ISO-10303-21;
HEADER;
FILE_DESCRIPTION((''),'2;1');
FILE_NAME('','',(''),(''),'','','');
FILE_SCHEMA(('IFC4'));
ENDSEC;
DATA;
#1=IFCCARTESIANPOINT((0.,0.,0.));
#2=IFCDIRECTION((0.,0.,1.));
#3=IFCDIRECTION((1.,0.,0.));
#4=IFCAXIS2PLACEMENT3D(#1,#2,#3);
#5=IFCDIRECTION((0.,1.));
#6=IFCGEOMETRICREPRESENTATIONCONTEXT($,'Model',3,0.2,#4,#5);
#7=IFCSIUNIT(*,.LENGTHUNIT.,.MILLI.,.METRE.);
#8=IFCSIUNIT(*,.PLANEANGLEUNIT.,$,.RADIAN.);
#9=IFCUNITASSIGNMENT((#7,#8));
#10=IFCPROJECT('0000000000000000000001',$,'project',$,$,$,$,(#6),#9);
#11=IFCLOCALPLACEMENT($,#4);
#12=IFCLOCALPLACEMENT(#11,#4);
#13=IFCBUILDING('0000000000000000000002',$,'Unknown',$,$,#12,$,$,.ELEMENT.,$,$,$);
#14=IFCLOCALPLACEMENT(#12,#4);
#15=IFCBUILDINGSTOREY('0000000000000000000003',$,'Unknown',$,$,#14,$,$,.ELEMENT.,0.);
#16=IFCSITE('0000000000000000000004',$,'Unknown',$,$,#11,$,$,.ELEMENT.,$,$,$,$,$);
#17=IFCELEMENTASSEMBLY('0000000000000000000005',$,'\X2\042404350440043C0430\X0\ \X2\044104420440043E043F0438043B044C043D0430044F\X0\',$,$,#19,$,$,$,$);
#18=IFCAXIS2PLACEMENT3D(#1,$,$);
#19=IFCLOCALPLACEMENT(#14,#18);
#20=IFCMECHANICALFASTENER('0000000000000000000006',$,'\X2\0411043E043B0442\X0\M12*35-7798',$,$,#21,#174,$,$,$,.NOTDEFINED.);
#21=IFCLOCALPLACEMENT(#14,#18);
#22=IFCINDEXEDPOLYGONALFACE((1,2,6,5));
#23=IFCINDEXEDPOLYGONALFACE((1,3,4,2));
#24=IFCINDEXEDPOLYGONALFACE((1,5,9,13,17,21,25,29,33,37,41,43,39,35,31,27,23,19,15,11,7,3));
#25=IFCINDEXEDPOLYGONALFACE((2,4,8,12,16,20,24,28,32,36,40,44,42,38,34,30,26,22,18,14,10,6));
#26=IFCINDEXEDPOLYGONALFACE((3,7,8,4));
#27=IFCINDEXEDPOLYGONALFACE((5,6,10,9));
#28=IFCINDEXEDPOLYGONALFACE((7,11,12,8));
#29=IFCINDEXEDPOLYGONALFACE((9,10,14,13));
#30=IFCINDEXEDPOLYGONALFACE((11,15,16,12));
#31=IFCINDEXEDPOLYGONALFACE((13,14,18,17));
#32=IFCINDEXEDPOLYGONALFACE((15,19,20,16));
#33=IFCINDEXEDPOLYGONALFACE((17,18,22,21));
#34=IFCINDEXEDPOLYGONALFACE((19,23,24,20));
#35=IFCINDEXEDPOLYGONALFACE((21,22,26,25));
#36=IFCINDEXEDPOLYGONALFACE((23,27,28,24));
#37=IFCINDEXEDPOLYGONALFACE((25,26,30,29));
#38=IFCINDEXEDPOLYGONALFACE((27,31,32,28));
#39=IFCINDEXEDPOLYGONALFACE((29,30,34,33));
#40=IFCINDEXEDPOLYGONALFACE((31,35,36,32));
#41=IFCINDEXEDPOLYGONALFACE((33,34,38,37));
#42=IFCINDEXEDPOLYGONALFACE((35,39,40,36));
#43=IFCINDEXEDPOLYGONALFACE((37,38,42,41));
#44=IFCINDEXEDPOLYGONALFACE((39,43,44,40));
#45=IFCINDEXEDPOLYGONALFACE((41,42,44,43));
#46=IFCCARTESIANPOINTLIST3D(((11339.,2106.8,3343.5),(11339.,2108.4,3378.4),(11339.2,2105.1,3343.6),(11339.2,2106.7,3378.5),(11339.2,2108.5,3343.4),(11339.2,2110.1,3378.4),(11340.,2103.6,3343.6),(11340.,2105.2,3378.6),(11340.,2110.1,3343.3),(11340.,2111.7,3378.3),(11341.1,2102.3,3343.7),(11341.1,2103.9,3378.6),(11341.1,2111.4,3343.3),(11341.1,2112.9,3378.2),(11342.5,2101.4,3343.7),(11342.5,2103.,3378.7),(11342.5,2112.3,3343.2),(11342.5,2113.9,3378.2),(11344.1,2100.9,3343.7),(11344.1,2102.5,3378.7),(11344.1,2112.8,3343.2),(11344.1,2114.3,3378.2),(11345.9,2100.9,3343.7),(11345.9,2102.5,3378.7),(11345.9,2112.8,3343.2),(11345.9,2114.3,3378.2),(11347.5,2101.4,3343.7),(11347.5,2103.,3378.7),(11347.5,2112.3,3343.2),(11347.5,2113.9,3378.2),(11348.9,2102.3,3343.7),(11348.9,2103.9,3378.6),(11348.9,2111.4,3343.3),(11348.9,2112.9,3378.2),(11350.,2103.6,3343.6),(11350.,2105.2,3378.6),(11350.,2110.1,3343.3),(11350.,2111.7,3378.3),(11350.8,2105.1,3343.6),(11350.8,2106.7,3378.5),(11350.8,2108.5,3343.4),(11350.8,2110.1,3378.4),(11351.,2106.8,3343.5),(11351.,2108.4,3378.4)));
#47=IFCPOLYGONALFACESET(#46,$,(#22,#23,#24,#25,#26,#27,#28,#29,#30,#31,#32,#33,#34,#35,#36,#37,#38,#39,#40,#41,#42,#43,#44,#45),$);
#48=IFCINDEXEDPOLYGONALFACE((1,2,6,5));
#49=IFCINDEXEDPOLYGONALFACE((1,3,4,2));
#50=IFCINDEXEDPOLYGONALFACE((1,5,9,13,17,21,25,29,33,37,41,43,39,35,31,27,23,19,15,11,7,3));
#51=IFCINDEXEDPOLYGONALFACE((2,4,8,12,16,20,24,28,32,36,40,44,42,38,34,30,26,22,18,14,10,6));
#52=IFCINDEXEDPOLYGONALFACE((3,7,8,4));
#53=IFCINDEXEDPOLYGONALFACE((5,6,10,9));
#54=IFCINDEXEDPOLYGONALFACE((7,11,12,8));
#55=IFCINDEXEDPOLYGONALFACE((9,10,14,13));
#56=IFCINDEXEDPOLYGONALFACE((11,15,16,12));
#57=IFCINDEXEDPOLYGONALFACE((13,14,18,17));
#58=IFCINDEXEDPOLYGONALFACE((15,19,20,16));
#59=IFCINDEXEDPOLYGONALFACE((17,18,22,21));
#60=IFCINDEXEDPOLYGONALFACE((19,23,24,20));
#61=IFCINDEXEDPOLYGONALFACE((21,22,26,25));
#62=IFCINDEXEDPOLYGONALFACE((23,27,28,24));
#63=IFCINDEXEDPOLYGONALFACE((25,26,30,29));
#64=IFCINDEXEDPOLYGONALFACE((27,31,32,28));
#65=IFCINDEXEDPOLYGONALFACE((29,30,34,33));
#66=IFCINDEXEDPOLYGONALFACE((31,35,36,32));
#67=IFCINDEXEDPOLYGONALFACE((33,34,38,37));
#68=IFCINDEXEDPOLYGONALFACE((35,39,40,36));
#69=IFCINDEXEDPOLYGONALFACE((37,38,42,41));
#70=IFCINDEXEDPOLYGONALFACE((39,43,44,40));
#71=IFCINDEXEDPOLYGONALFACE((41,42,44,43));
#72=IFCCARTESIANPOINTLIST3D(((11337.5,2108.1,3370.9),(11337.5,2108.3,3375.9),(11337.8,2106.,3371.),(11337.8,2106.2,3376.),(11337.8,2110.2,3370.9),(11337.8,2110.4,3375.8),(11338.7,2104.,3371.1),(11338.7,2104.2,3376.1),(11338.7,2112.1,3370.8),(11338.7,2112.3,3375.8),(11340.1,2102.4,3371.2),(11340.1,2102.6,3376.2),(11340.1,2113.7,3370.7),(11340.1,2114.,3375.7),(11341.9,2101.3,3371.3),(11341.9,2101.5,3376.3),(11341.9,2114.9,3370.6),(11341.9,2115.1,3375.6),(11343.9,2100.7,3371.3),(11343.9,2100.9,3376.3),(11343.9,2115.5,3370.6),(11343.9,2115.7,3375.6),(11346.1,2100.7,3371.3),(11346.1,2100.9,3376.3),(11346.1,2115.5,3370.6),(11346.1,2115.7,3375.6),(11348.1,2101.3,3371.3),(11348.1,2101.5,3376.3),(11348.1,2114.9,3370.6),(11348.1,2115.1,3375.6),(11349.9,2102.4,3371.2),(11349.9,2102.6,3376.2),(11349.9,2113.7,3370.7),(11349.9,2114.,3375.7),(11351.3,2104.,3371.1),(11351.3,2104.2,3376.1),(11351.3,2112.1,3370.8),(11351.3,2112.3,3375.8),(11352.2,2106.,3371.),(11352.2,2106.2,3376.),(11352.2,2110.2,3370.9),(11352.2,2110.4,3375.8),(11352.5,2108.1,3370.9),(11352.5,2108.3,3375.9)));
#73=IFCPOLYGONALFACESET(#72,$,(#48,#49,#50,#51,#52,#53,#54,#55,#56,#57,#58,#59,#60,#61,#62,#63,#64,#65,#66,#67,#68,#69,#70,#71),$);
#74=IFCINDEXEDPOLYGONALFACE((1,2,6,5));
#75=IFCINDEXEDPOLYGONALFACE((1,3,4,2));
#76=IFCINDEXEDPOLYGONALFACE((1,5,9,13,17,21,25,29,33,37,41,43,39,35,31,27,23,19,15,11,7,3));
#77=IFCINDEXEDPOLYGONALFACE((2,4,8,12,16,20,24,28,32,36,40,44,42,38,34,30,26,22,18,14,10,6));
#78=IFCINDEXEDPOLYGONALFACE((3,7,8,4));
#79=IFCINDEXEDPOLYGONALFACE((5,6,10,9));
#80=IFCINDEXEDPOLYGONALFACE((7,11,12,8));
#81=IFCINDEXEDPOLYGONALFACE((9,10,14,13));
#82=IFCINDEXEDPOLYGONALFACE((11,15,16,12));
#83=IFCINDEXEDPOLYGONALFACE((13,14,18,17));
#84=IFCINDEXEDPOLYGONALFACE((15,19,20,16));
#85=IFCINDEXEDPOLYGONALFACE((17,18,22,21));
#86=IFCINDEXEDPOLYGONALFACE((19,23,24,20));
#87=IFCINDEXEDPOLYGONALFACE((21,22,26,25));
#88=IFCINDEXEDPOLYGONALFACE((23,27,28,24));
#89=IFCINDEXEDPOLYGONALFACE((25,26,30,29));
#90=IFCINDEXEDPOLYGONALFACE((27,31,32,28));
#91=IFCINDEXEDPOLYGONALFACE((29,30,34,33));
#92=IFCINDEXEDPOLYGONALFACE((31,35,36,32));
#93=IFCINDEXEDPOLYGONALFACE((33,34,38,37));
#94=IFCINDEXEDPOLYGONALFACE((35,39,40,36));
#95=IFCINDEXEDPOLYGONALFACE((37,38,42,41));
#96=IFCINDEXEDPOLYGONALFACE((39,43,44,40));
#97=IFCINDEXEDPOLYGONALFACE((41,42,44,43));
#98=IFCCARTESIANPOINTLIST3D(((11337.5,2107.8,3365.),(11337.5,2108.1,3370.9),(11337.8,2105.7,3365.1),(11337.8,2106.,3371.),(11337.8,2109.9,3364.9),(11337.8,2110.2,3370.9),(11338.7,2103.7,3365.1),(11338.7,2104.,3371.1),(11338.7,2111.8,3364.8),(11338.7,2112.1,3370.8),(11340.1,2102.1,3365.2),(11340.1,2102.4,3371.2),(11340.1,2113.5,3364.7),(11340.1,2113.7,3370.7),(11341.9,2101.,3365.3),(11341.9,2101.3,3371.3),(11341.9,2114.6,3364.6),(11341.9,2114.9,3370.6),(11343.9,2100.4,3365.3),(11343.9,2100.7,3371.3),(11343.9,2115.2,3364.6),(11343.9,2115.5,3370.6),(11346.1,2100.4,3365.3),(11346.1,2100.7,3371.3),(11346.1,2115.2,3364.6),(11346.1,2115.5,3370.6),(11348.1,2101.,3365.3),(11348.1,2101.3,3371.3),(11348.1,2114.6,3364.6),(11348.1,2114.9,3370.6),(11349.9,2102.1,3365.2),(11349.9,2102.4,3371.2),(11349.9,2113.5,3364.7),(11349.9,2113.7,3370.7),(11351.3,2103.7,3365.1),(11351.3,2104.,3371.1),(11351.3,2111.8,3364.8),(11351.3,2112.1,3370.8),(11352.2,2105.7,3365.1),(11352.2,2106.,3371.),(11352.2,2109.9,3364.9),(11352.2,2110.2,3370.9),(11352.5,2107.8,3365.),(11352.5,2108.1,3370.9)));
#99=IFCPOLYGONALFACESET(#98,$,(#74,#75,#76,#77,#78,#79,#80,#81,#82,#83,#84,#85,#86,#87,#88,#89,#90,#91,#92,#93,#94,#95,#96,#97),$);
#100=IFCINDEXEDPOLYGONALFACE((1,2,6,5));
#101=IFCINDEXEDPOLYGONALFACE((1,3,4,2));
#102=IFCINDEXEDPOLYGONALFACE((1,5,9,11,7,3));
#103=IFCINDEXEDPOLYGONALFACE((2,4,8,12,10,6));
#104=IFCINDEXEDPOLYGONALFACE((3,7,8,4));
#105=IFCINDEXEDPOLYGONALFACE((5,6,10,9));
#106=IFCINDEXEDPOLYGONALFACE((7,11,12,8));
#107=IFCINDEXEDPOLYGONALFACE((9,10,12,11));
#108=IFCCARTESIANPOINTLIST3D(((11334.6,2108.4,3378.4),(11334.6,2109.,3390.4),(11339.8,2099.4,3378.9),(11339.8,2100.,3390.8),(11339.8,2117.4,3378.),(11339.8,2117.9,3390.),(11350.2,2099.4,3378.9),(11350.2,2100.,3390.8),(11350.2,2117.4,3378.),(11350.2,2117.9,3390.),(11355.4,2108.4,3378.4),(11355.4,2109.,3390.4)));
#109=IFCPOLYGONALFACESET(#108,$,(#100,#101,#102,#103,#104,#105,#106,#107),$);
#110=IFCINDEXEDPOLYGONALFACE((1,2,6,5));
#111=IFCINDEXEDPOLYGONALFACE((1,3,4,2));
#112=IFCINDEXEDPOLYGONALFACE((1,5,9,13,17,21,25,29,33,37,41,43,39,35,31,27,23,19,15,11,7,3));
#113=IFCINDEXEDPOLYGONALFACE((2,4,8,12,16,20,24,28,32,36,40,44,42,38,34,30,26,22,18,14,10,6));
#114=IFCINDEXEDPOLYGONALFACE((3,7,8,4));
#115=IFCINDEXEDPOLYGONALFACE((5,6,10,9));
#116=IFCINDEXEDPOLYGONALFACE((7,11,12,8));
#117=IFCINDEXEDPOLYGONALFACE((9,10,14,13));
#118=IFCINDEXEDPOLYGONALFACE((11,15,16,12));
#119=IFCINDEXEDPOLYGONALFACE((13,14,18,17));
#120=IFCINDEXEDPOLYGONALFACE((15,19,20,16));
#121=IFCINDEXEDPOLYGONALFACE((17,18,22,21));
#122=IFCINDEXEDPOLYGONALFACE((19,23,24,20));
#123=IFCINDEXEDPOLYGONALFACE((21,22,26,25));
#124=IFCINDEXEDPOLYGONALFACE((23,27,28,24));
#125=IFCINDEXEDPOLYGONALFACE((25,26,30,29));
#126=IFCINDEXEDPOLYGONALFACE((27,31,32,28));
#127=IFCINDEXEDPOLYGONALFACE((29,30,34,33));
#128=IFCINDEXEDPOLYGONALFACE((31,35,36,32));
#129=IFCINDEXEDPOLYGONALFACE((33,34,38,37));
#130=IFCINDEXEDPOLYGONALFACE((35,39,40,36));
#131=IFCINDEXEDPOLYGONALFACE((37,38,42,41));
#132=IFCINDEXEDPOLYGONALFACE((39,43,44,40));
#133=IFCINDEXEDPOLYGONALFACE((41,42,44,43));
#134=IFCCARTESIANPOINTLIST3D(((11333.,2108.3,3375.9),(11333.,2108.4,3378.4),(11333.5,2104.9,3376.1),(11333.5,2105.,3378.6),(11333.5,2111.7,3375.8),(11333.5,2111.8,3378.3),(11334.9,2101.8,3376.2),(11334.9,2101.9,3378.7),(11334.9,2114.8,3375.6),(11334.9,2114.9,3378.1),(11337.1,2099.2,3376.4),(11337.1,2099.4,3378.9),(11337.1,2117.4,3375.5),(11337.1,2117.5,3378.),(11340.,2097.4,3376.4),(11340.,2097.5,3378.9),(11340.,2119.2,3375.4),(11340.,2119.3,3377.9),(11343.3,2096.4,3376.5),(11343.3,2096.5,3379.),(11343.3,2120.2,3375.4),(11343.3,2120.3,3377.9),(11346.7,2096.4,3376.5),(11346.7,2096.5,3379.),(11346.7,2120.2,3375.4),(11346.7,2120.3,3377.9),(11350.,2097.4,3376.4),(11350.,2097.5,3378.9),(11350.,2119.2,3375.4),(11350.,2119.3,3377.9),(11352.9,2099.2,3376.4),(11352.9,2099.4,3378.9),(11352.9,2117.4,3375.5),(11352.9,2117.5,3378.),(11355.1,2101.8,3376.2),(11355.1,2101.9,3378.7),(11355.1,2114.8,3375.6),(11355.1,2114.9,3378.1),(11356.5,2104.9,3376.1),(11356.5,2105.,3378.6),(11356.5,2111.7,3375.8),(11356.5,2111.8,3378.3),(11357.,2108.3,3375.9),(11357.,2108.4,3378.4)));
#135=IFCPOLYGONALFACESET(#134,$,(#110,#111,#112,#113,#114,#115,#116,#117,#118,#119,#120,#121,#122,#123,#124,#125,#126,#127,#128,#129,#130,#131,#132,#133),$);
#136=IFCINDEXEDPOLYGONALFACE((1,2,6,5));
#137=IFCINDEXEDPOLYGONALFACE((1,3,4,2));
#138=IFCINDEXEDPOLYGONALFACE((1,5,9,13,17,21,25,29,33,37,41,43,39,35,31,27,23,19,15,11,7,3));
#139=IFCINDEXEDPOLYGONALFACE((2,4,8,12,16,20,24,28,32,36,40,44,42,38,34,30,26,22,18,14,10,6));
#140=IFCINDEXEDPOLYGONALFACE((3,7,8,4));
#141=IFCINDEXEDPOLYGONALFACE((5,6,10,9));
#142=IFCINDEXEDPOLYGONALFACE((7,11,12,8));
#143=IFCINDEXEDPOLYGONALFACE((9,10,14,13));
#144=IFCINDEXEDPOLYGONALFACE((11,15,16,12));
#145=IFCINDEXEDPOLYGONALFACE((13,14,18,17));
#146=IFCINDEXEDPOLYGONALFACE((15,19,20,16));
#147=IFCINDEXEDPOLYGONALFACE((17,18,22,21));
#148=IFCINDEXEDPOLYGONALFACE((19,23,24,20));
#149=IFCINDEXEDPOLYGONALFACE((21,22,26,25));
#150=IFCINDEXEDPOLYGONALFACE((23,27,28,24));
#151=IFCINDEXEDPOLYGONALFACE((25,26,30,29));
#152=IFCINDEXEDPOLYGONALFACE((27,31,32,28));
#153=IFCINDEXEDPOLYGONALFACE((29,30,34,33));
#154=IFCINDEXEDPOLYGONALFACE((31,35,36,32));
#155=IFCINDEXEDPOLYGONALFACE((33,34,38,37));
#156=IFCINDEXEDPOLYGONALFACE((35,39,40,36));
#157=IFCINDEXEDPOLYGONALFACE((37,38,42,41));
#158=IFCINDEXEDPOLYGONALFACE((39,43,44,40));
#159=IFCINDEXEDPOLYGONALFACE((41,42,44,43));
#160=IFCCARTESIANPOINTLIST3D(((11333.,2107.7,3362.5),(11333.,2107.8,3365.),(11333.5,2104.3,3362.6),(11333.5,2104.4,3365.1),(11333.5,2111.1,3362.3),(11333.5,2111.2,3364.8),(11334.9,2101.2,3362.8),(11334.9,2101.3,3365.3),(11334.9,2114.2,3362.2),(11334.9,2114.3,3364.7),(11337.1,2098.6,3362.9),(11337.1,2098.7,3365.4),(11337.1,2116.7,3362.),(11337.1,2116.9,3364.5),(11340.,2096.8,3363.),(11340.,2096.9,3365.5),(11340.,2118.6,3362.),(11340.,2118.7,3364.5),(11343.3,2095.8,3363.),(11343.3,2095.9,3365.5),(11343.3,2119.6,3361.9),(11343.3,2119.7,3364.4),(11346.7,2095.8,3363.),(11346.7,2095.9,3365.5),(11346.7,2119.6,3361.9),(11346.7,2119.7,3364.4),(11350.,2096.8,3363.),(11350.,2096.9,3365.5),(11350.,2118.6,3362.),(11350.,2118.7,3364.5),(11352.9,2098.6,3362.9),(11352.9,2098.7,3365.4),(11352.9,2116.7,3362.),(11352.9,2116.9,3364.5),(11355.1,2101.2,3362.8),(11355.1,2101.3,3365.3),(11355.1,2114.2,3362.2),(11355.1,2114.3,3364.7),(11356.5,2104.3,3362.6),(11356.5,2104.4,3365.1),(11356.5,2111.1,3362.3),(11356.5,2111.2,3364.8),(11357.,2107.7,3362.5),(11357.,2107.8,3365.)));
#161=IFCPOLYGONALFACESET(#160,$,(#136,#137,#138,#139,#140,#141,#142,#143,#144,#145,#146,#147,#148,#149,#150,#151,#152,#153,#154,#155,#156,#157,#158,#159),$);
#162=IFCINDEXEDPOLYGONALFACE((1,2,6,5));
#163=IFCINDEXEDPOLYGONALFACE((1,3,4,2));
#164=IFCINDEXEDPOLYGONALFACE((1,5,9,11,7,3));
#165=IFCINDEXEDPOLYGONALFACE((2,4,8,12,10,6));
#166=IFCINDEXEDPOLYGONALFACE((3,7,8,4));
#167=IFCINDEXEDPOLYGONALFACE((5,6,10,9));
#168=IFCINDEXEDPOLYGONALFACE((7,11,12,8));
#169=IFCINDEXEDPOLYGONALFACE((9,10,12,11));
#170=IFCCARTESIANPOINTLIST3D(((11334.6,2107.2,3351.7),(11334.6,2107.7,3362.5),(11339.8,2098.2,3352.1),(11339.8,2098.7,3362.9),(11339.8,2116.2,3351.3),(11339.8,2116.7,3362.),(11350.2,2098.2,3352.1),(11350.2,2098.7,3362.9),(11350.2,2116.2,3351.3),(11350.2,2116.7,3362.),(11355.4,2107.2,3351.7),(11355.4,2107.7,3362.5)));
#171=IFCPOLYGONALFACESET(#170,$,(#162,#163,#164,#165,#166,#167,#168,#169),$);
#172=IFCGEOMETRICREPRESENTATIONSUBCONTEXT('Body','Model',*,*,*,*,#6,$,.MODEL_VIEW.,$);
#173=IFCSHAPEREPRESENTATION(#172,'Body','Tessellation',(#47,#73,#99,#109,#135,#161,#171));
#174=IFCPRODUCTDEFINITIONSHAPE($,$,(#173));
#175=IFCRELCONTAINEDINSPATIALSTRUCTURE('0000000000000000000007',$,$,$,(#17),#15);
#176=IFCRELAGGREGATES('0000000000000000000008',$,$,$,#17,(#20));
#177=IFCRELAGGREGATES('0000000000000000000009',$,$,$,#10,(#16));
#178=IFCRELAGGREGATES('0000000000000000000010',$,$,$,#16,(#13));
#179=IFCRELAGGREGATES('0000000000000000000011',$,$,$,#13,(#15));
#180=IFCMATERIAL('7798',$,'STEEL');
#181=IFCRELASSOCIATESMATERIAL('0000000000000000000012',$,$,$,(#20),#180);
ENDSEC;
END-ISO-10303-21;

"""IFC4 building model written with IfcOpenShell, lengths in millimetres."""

from ifc_helpers import new_model, si_unit, direction, frame, origin_with_axes, place, context, subcontext, project, spatial, line, arc, indexed_curve, outline, extrude, source, transform, mapped, material, element, aggregate, save


model = new_model("IFC4")

# Units and contexts
model_context = context("Model", 3, precision=0.2, world=origin_with_axes(), true_north=direction((0.0, 1.0)))
body_context = subcontext(model_context, "Body", "Model", "MODEL_VIEW")
ifc_project = project(units=[si_unit("LENGTHUNIT", "METRE", prefix="MILLI"), si_unit("PLANEANGLEUNIT", "RADIAN")], contexts=[model_context])

# Site, building, storey
site_placement = place(None, origin_with_axes())
site = spatial("IfcSite", under=ifc_project, at=site_placement, Name="Unknown", CompositionType="ELEMENT")
building_placement = place(site_placement, origin_with_axes())
building = spatial("IfcBuilding", under=site, at=building_placement, Name="Unknown", CompositionType="ELEMENT")
storey_placement = place(building_placement, origin_with_axes())
storey = spatial("IfcBuildingStorey", under=building, at=storey_placement, Name="Unknown", CompositionType="ELEMENT", Elevation=0.0)

# Element assembly
assembly_1_placement = place(storey_placement, frame((11400.0, 88.6, 3426.7), z_axis=(1.0, 0.0, 0.0), x_axis=(0.0, 0.998969, -0.045408)))
assembly_1 = element("IfcElementAssembly", 1, at=assembly_1_placement, inside=storey, Name="Ферма стропильная")

# Mechanical fastener
ifc_material_1 = material(Name="7798", Category="STEEL")
shared_shape_1 = source(origin_with_axes(), body_context, "Body", "SweptSolid", [
    extrude(outline(indexed_curve([(6.0, 0.0), (0.0, 6.0), (-6.0, 0.0), (0.0, -6.0)], segments=[arc(1, 2, 3), arc(3, 4, 1)])), frame((0.0, 0.0, 7.5), z_axis=(0.0, 0.0, -1.0), x_axis=(0.0, 1.0, 0.0)), (0.0, 0.0, 1.0), 35.0),
    extrude(outline(indexed_curve([(7.5, 0.0), (0.0, 7.5), (-7.5, 0.0), (0.0, -7.5)], segments=[arc(1, 2, 3), arc(3, 4, 1)])), frame((0.0, 0.0, 5.0), z_axis=(0.0, 0.0, -1.0), x_axis=(0.0, 1.0, 0.0)), (0.0, 0.0, 1.0), 5.0),
    extrude(outline(indexed_curve([(7.5, 0.0), (0.0, 7.5), (-7.5, 0.0), (0.0, -7.5)], segments=[arc(1, 2, 3), arc(3, 4, 1)])), frame((0.0, 0.0, 0.0), z_axis=(0.0, 0.0, -1.0), x_axis=(0.0, 1.0, 0.0)), (0.0, 0.0, 1.0), 6.0),
    extrude(outline(indexed_curve([(10.4, 0.0), (5.2, 9.0), (-5.2, 9.0), (-10.4, 0.0), (-5.2, -9.0), (5.2, -9.0)], segments=[line(1, 2, 3, 4, 5, 6, 1)])), frame((0.0, 0.0, 19.5), z_axis=(0.0, 0.0, -1.0), x_axis=(0.0, 1.0, 0.0)), (0.0, 0.0, 1.0), 12.0),
    extrude(outline(indexed_curve([(12.0, 0.0), (0.0, 12.0), (-12.0, 0.0), (0.0, -12.0)], segments=[arc(1, 2, 3), arc(3, 4, 1)])), frame((0.0, 0.0, 7.5), z_axis=(0.0, 0.0, -1.0), x_axis=(0.0, 1.0, 0.0)), (0.0, 0.0, 1.0), 2.5),
    extrude(outline(indexed_curve([(12.0, 0.0), (0.0, 12.0), (-12.0, 0.0), (0.0, -12.0)], segments=[arc(1, 2, 3), arc(3, 4, 1)])), frame((0.0, 0.0, -6.0), z_axis=(0.0, 0.0, -1.0), x_axis=(0.0, 1.0, 0.0)), (0.0, 0.0, 1.0), 2.5),
    extrude(outline(indexed_curve([(10.4, 0.0), (5.2, 9.0), (-5.2, 9.0), (-10.4, 0.0), (-5.2, -9.0), (5.2, -9.0)], segments=[line(1, 2, 3, 4, 5, 6, 1)])), frame((0.0, 0.0, -8.5), z_axis=(0.0, 0.0, -1.0), x_axis=(0.0, 1.0, 0.0)), (0.0, 0.0, 1.0), 10.8),
])
mechanical_fastener_1_placement = place(assembly_1_placement, frame((2019.9, 36.0, -55.0), z_axis=(0.0, 1.0, 0.0), x_axis=(1.0, 0.0, 0.0)))
mechanical_fastener_1 = element("IfcMechanicalFastener", 2, at=mechanical_fastener_1_placement, material=ifc_material_1, Name="БолтM12*35-7798", PredefinedType="NOTDEFINED", context=body_context, shape_type="MappedRepresentation", body=[
    mapped(shared_shape_1, transform((0.0, 0.0, 0.0))),
])
aggregate(assembly_1, [mechanical_fastener_1])

save(model, "model.ifc")
